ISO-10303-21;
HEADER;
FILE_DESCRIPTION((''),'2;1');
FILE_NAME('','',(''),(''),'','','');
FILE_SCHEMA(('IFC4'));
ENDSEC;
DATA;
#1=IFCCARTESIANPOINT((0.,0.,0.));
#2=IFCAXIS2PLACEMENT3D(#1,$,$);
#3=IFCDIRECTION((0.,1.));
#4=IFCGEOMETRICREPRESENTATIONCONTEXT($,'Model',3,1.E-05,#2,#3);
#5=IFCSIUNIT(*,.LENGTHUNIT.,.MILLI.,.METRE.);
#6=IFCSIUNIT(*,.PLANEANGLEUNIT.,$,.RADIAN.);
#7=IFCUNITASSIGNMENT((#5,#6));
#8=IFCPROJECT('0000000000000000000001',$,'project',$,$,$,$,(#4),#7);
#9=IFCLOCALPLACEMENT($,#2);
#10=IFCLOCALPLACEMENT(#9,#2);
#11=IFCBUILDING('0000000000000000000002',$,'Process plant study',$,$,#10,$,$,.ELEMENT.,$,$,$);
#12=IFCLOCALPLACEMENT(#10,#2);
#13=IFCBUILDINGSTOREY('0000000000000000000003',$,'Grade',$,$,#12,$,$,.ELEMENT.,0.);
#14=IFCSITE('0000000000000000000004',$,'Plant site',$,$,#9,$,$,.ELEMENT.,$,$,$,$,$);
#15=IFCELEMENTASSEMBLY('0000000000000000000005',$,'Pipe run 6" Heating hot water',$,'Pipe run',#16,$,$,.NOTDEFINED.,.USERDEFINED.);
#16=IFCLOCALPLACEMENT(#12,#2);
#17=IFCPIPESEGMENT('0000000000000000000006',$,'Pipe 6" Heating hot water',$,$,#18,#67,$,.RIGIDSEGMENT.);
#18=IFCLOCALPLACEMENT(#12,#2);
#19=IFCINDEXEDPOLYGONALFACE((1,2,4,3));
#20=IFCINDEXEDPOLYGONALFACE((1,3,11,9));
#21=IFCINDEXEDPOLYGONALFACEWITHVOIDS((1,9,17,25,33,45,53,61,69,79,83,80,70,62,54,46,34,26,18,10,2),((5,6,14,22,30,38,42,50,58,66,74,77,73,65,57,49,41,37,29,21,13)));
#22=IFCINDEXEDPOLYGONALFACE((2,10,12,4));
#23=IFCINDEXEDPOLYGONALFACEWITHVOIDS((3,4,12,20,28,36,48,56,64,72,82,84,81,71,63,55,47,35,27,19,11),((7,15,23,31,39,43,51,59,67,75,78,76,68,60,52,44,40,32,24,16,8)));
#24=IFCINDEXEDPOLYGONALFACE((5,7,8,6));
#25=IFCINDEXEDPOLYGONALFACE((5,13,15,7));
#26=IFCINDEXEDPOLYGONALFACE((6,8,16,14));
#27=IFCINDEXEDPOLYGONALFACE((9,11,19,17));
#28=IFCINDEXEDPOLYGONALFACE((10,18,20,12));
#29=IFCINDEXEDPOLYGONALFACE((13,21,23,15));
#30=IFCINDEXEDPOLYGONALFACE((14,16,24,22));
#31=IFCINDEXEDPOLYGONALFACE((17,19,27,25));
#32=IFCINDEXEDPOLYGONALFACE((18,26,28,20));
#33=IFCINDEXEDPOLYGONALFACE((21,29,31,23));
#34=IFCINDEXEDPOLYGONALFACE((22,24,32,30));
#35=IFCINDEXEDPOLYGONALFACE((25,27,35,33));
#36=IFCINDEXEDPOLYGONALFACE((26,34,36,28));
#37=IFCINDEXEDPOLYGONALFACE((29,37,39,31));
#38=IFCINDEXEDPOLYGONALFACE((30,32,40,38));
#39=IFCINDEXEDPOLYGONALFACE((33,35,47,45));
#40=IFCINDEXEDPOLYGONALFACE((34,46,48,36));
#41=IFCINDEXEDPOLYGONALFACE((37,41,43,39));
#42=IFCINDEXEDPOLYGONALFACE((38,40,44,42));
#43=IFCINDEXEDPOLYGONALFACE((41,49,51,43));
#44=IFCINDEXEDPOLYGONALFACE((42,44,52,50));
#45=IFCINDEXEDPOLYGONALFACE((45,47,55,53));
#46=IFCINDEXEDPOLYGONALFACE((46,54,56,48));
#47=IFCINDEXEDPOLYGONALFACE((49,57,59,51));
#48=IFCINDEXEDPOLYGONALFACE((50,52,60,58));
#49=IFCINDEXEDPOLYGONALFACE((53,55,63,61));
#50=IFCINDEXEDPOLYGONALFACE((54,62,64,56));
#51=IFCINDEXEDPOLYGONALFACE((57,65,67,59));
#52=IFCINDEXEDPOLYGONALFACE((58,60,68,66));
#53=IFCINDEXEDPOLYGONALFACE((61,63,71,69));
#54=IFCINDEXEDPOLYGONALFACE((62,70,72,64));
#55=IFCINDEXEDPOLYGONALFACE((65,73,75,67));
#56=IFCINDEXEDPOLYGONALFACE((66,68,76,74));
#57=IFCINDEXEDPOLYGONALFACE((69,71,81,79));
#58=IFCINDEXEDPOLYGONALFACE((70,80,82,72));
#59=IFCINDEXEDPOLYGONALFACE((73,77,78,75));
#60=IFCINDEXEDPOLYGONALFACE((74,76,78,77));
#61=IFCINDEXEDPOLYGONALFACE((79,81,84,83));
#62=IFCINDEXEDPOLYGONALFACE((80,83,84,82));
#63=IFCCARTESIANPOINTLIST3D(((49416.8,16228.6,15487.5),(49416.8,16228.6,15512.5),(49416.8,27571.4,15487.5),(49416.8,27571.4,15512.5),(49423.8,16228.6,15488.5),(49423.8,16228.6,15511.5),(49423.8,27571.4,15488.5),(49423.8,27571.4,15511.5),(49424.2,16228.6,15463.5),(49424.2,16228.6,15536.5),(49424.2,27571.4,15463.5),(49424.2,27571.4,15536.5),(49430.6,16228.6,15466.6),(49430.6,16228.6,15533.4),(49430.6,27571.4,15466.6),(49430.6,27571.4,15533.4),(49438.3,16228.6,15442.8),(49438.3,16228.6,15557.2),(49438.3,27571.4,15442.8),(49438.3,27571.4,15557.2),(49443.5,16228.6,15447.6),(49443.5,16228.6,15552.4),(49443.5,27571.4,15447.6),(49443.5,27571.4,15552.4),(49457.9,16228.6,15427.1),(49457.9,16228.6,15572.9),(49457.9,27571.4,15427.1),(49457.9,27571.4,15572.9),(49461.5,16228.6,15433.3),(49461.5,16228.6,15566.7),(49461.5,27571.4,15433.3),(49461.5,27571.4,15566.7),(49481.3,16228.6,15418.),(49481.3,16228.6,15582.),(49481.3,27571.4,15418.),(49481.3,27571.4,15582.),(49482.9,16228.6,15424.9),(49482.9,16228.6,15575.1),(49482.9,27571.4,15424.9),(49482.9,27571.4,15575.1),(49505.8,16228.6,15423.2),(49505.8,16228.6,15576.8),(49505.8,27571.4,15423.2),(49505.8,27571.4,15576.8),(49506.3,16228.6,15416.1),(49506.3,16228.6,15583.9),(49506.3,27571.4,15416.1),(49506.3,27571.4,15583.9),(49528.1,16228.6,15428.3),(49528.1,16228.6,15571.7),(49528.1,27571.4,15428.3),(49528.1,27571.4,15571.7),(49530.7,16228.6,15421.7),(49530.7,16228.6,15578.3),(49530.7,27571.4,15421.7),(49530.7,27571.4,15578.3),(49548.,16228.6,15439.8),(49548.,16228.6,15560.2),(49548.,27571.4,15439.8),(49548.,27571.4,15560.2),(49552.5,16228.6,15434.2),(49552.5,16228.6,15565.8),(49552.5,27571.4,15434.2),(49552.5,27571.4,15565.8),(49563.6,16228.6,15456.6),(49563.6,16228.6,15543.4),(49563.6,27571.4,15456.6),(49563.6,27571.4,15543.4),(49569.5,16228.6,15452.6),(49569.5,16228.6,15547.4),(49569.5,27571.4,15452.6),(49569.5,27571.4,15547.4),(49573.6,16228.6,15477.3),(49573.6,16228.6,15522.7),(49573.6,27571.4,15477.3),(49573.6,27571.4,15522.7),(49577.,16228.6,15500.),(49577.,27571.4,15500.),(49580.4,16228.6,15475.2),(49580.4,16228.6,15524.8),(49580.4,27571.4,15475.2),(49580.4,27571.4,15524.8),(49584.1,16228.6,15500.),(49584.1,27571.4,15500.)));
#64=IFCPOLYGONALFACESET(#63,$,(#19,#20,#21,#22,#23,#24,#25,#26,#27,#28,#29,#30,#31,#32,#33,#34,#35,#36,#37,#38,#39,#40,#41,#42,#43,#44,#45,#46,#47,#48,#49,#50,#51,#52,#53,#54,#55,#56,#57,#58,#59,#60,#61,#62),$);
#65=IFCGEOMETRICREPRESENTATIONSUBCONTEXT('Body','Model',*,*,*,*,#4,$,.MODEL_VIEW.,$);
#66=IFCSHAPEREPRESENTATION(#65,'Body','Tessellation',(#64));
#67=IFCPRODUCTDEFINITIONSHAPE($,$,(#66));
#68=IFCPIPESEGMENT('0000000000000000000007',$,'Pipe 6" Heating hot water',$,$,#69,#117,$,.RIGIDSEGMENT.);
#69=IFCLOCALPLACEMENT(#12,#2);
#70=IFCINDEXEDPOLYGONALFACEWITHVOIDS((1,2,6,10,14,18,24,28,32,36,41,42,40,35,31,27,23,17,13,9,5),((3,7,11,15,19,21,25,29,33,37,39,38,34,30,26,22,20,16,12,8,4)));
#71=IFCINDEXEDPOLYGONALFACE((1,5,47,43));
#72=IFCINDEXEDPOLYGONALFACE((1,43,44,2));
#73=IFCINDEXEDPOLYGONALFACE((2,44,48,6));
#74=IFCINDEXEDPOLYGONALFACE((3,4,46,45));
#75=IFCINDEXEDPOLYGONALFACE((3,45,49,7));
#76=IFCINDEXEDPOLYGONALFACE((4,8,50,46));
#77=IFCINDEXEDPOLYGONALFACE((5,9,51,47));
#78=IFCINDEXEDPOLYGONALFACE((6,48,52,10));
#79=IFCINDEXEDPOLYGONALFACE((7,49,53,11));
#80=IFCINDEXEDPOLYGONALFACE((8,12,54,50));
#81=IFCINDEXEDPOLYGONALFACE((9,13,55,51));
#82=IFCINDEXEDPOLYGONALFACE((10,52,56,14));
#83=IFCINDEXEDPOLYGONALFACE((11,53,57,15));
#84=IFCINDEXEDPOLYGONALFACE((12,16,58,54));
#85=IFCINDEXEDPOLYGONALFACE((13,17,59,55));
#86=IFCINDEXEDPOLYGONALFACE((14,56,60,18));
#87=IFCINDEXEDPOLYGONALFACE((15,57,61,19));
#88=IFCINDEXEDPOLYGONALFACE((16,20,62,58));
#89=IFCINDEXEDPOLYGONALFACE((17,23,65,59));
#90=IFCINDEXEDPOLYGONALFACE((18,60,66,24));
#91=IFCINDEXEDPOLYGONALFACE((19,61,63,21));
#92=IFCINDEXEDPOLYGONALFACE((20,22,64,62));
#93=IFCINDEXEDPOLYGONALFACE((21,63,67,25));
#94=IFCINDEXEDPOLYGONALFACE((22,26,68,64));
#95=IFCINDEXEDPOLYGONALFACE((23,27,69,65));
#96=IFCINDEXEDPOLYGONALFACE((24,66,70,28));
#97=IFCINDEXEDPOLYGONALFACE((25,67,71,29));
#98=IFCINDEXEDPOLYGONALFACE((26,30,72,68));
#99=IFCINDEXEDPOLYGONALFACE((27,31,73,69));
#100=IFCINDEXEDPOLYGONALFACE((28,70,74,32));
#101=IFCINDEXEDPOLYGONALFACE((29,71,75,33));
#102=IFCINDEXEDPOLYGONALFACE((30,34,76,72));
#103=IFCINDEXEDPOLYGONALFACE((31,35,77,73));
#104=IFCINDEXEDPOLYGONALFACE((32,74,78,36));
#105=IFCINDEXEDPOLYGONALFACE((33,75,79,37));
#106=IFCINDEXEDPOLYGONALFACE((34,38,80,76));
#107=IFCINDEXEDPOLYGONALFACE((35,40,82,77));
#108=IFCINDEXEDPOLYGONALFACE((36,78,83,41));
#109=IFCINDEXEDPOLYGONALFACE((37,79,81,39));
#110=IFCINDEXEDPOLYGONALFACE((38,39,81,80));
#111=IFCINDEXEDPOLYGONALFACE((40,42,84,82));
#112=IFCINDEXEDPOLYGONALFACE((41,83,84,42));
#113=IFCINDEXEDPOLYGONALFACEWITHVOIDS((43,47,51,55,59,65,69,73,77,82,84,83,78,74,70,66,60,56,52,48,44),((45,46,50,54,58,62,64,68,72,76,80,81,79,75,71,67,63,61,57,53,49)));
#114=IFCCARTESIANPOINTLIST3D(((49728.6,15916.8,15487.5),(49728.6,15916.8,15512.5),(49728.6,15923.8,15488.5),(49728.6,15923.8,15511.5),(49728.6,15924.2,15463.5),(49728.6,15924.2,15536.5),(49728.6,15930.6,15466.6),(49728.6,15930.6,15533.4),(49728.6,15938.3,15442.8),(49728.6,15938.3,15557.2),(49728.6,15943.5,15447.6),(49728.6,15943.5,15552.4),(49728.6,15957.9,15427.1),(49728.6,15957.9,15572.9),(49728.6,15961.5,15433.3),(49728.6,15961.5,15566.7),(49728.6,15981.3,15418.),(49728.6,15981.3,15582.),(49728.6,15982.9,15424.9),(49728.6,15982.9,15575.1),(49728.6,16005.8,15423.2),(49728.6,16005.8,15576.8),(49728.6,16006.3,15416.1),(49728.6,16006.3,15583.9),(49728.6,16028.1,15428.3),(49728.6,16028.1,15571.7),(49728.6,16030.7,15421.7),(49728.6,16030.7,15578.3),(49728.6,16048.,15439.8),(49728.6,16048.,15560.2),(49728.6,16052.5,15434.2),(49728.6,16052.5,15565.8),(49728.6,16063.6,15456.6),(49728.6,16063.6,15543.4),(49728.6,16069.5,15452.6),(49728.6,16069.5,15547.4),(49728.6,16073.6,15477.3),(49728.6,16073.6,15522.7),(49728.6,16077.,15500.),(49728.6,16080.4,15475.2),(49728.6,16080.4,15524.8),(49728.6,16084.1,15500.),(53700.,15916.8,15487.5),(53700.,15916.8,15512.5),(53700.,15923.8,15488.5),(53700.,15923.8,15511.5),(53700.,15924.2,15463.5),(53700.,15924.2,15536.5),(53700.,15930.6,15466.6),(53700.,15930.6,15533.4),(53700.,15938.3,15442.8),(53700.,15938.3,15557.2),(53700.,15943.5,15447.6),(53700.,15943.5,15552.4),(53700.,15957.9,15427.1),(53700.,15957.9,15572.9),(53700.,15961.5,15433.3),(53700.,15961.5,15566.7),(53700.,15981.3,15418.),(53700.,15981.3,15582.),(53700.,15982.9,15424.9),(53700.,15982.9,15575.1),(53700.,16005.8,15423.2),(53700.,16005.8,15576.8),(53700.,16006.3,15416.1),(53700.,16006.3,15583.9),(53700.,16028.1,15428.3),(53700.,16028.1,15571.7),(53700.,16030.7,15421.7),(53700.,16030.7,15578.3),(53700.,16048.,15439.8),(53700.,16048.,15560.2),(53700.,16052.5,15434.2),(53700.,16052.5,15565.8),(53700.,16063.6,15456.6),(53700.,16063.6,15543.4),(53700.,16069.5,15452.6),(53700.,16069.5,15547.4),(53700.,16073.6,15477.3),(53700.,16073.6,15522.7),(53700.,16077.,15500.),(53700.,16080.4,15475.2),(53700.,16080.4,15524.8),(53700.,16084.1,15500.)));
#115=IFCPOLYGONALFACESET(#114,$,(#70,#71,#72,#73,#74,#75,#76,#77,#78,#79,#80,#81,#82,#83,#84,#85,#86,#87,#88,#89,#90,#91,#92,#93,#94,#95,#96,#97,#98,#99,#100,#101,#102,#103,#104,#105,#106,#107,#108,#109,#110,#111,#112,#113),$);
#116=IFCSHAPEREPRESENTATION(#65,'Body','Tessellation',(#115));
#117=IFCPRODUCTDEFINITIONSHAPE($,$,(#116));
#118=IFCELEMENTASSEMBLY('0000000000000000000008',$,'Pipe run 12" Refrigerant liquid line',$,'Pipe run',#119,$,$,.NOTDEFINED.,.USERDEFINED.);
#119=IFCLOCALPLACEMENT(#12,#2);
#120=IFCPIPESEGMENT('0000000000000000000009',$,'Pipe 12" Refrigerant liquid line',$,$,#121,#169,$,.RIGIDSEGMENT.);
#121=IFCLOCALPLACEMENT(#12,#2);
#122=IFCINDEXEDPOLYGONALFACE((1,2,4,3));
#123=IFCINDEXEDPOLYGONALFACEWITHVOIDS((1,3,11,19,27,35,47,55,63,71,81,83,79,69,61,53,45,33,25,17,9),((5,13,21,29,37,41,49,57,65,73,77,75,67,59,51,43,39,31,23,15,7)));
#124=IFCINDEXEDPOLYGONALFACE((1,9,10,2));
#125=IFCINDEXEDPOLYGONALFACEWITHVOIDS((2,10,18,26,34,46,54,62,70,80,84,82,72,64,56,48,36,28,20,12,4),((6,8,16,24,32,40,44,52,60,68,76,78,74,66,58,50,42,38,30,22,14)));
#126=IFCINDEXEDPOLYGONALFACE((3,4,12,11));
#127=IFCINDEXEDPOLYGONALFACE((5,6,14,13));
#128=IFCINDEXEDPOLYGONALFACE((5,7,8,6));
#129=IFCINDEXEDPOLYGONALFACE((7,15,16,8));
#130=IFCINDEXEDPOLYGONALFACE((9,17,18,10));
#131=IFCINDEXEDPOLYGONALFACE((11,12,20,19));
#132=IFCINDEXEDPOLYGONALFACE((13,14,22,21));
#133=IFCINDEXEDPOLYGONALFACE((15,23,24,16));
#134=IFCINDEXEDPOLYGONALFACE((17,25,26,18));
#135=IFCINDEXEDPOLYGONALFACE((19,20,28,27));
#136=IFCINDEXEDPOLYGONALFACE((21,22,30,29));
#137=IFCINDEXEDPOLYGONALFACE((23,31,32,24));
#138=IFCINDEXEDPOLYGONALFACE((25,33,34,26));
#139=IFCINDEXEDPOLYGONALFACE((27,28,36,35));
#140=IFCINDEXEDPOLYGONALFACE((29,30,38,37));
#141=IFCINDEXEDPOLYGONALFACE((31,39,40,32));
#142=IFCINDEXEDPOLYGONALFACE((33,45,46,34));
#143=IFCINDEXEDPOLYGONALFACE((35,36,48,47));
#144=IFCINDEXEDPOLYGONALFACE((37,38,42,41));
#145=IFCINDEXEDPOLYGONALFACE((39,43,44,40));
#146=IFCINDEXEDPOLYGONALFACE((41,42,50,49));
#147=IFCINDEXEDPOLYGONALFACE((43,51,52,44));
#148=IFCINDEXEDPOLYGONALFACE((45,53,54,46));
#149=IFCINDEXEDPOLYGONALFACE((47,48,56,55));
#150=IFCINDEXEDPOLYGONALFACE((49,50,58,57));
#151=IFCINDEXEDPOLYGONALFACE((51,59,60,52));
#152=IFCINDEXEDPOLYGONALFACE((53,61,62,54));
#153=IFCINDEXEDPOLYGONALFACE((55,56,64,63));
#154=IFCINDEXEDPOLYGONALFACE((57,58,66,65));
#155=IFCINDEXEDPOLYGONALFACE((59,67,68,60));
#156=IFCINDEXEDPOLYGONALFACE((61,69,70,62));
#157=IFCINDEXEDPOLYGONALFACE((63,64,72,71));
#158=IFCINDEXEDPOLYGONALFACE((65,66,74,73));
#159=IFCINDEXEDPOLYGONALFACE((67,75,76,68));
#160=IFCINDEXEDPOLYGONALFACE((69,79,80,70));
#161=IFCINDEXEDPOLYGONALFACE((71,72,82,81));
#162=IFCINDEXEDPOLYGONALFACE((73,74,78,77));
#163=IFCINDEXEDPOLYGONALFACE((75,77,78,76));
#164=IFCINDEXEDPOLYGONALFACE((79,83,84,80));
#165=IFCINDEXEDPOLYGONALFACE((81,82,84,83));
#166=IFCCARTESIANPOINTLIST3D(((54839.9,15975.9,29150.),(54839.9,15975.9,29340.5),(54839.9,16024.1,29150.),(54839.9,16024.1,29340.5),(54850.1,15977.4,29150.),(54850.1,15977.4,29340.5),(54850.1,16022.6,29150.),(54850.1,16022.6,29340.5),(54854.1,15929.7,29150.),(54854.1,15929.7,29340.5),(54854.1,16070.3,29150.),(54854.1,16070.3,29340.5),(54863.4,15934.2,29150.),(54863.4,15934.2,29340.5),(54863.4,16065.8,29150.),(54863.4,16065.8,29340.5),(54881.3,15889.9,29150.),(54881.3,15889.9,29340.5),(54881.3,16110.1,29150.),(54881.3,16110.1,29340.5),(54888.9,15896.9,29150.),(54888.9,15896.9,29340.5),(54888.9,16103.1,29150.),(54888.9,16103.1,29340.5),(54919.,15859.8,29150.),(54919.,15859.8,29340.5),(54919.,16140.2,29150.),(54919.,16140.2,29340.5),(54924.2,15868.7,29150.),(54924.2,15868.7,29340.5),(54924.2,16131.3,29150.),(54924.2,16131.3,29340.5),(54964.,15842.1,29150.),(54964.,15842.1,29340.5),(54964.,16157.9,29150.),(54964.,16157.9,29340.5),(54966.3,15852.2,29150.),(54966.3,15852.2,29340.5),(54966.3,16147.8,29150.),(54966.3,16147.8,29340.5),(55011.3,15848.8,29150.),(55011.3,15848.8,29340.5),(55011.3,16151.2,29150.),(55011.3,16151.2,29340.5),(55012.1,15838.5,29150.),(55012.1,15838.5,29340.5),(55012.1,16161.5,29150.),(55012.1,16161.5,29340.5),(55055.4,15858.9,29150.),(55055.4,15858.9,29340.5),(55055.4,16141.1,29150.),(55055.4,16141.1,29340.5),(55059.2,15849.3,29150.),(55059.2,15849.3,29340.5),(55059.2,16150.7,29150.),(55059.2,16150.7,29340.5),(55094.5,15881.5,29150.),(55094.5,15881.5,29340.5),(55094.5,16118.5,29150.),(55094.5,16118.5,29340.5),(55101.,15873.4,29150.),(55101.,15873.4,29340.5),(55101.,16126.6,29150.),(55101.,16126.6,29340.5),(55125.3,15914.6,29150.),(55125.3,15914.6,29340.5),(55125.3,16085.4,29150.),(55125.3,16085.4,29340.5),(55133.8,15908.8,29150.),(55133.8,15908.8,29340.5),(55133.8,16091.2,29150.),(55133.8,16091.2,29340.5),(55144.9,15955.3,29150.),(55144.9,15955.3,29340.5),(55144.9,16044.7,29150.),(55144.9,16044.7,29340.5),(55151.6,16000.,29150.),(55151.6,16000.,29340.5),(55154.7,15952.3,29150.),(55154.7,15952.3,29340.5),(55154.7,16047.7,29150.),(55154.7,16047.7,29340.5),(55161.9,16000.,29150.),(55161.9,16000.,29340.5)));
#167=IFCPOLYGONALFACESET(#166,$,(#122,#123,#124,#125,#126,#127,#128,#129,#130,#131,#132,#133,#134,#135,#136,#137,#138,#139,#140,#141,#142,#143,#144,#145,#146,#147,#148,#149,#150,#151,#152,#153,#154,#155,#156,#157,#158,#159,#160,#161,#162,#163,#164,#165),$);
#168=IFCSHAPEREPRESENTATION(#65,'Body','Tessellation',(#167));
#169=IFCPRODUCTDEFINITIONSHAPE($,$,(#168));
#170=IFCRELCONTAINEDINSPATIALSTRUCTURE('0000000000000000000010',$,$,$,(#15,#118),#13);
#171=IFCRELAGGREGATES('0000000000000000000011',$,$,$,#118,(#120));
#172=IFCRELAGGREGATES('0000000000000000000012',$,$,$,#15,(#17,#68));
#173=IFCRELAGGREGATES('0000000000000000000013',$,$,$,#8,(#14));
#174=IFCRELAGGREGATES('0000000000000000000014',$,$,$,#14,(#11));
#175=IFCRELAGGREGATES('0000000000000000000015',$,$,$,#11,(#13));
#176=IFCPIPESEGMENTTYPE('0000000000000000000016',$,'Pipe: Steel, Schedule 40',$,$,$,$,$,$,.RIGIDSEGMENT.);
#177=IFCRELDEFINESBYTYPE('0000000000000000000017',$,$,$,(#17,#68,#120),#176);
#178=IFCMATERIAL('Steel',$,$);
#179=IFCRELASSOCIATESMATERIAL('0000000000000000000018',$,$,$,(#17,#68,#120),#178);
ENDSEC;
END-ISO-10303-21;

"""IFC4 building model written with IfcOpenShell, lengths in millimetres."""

from ifc_helpers import new_model, si_unit, direction, frame, origin, origin_with_axes, origin_2d, place, context, subcontext, project, spatial, hollow_circle, extrude, material, type_object, element, aggregate, save


model = new_model("IFC4")

# Units and contexts
model_context = context("Model", 3, precision=1e-05, world=origin(), true_north=direction((0.0, 1.0)))
body_context = subcontext(model_context, "Body", "Model", "MODEL_VIEW")
ifc_project = project(units=[si_unit("LENGTHUNIT", "METRE", prefix="MILLI"), si_unit("PLANEANGLEUNIT", "RADIAN")], contexts=[model_context])

# Site, building, storey
site_placement = place(None, origin())
site = spatial("IfcSite", under=ifc_project, at=site_placement, Name="Plant site", CompositionType="ELEMENT")
building_placement = place(site_placement, origin())
building = spatial("IfcBuilding", under=site, at=building_placement, Name="Process plant study", CompositionType="ELEMENT")
storey_placement = place(building_placement, origin())
storey = spatial("IfcBuildingStorey", under=building, at=storey_placement, Name="Grade", CompositionType="ELEMENT", Elevation=0.0)

# Element assembly, pipe segments
ifc_material = material(Name="Steel")
pipe_segment_type = type_object("IfcPipeSegmentType", Name="Pipe: Steel, Schedule 40", PredefinedType="RIGIDSEGMENT")
assembly_1_placement = place(storey_placement, origin_with_axes())
assembly_1 = element("IfcElementAssembly", 1, at=assembly_1_placement, inside=storey, Name="Pipe run 6\" Heating hot water", ObjectType="Pipe run", AssemblyPlace="NOTDEFINED", PredefinedType="USERDEFINED")
pipe_segment_1_placement = place(storey_placement, origin_with_axes())
pipe_segment_1 = element("IfcPipeSegment", 2, at=pipe_segment_1_placement, type_object=pipe_segment_type, material=ifc_material, Name="Pipe 6\" Heating hot water", PredefinedType="RIGIDSEGMENT", context=body_context, shape_type="SweptSolid", body=[
    extrude(hollow_circle(Radius=84.1, WallThickness=7.1, at=origin_2d()), frame((49500.0, 27571.4, 15500.0), z_axis=(0.0, -1.0, 0.0), x_axis=(1.0, 0.0, 0.0)), (0.0, 0.0, 1.0), 11342.8),
])
pipe_segment_2_placement = place(storey_placement, origin_with_axes())
pipe_segment_2 = element("IfcPipeSegment", 3, at=pipe_segment_2_placement, type_object=pipe_segment_type, material=ifc_material, Name="Pipe 6\" Heating hot water", PredefinedType="RIGIDSEGMENT", context=body_context, shape_type="SweptSolid", body=[
    extrude(hollow_circle(Radius=84.1, WallThickness=7.1, at=origin_2d()), frame((49728.6, 16000.0, 15500.0), z_axis=(1.0, 0.0, 0.0), x_axis=(0.0, 1.0, 0.0)), (0.0, 0.0, 1.0), 3971.4),
])

# Element assembly, pipe segment
assembly_2_placement = place(storey_placement, origin_with_axes())
assembly_2 = element("IfcElementAssembly", 4, at=assembly_2_placement, inside=storey, Name="Pipe run 12\" Refrigerant liquid line", ObjectType="Pipe run", AssemblyPlace="NOTDEFINED", PredefinedType="USERDEFINED")
pipe_segment_3_placement = place(storey_placement, origin_with_axes())
pipe_segment_3 = element("IfcPipeSegment", 5, at=pipe_segment_3_placement, type_object=pipe_segment_type, material=ifc_material, Name="Pipe 12\" Refrigerant liquid line", PredefinedType="RIGIDSEGMENT", context=body_context, shape_type="SweptSolid", body=[
    extrude(hollow_circle(Radius=161.9, WallThickness=10.3, at=origin_2d()), frame((55000.0, 16000.0, 29150.0), z_axis=(0.0, 0.0, 1.0), x_axis=(1.0, 0.0, 0.0)), (0.0, 0.0, 1.0), 190.5),
])
aggregate(assembly_2, [pipe_segment_3])

aggregate(assembly_1, [pipe_segment_1, pipe_segment_2])

save(model, "model.ifc")
